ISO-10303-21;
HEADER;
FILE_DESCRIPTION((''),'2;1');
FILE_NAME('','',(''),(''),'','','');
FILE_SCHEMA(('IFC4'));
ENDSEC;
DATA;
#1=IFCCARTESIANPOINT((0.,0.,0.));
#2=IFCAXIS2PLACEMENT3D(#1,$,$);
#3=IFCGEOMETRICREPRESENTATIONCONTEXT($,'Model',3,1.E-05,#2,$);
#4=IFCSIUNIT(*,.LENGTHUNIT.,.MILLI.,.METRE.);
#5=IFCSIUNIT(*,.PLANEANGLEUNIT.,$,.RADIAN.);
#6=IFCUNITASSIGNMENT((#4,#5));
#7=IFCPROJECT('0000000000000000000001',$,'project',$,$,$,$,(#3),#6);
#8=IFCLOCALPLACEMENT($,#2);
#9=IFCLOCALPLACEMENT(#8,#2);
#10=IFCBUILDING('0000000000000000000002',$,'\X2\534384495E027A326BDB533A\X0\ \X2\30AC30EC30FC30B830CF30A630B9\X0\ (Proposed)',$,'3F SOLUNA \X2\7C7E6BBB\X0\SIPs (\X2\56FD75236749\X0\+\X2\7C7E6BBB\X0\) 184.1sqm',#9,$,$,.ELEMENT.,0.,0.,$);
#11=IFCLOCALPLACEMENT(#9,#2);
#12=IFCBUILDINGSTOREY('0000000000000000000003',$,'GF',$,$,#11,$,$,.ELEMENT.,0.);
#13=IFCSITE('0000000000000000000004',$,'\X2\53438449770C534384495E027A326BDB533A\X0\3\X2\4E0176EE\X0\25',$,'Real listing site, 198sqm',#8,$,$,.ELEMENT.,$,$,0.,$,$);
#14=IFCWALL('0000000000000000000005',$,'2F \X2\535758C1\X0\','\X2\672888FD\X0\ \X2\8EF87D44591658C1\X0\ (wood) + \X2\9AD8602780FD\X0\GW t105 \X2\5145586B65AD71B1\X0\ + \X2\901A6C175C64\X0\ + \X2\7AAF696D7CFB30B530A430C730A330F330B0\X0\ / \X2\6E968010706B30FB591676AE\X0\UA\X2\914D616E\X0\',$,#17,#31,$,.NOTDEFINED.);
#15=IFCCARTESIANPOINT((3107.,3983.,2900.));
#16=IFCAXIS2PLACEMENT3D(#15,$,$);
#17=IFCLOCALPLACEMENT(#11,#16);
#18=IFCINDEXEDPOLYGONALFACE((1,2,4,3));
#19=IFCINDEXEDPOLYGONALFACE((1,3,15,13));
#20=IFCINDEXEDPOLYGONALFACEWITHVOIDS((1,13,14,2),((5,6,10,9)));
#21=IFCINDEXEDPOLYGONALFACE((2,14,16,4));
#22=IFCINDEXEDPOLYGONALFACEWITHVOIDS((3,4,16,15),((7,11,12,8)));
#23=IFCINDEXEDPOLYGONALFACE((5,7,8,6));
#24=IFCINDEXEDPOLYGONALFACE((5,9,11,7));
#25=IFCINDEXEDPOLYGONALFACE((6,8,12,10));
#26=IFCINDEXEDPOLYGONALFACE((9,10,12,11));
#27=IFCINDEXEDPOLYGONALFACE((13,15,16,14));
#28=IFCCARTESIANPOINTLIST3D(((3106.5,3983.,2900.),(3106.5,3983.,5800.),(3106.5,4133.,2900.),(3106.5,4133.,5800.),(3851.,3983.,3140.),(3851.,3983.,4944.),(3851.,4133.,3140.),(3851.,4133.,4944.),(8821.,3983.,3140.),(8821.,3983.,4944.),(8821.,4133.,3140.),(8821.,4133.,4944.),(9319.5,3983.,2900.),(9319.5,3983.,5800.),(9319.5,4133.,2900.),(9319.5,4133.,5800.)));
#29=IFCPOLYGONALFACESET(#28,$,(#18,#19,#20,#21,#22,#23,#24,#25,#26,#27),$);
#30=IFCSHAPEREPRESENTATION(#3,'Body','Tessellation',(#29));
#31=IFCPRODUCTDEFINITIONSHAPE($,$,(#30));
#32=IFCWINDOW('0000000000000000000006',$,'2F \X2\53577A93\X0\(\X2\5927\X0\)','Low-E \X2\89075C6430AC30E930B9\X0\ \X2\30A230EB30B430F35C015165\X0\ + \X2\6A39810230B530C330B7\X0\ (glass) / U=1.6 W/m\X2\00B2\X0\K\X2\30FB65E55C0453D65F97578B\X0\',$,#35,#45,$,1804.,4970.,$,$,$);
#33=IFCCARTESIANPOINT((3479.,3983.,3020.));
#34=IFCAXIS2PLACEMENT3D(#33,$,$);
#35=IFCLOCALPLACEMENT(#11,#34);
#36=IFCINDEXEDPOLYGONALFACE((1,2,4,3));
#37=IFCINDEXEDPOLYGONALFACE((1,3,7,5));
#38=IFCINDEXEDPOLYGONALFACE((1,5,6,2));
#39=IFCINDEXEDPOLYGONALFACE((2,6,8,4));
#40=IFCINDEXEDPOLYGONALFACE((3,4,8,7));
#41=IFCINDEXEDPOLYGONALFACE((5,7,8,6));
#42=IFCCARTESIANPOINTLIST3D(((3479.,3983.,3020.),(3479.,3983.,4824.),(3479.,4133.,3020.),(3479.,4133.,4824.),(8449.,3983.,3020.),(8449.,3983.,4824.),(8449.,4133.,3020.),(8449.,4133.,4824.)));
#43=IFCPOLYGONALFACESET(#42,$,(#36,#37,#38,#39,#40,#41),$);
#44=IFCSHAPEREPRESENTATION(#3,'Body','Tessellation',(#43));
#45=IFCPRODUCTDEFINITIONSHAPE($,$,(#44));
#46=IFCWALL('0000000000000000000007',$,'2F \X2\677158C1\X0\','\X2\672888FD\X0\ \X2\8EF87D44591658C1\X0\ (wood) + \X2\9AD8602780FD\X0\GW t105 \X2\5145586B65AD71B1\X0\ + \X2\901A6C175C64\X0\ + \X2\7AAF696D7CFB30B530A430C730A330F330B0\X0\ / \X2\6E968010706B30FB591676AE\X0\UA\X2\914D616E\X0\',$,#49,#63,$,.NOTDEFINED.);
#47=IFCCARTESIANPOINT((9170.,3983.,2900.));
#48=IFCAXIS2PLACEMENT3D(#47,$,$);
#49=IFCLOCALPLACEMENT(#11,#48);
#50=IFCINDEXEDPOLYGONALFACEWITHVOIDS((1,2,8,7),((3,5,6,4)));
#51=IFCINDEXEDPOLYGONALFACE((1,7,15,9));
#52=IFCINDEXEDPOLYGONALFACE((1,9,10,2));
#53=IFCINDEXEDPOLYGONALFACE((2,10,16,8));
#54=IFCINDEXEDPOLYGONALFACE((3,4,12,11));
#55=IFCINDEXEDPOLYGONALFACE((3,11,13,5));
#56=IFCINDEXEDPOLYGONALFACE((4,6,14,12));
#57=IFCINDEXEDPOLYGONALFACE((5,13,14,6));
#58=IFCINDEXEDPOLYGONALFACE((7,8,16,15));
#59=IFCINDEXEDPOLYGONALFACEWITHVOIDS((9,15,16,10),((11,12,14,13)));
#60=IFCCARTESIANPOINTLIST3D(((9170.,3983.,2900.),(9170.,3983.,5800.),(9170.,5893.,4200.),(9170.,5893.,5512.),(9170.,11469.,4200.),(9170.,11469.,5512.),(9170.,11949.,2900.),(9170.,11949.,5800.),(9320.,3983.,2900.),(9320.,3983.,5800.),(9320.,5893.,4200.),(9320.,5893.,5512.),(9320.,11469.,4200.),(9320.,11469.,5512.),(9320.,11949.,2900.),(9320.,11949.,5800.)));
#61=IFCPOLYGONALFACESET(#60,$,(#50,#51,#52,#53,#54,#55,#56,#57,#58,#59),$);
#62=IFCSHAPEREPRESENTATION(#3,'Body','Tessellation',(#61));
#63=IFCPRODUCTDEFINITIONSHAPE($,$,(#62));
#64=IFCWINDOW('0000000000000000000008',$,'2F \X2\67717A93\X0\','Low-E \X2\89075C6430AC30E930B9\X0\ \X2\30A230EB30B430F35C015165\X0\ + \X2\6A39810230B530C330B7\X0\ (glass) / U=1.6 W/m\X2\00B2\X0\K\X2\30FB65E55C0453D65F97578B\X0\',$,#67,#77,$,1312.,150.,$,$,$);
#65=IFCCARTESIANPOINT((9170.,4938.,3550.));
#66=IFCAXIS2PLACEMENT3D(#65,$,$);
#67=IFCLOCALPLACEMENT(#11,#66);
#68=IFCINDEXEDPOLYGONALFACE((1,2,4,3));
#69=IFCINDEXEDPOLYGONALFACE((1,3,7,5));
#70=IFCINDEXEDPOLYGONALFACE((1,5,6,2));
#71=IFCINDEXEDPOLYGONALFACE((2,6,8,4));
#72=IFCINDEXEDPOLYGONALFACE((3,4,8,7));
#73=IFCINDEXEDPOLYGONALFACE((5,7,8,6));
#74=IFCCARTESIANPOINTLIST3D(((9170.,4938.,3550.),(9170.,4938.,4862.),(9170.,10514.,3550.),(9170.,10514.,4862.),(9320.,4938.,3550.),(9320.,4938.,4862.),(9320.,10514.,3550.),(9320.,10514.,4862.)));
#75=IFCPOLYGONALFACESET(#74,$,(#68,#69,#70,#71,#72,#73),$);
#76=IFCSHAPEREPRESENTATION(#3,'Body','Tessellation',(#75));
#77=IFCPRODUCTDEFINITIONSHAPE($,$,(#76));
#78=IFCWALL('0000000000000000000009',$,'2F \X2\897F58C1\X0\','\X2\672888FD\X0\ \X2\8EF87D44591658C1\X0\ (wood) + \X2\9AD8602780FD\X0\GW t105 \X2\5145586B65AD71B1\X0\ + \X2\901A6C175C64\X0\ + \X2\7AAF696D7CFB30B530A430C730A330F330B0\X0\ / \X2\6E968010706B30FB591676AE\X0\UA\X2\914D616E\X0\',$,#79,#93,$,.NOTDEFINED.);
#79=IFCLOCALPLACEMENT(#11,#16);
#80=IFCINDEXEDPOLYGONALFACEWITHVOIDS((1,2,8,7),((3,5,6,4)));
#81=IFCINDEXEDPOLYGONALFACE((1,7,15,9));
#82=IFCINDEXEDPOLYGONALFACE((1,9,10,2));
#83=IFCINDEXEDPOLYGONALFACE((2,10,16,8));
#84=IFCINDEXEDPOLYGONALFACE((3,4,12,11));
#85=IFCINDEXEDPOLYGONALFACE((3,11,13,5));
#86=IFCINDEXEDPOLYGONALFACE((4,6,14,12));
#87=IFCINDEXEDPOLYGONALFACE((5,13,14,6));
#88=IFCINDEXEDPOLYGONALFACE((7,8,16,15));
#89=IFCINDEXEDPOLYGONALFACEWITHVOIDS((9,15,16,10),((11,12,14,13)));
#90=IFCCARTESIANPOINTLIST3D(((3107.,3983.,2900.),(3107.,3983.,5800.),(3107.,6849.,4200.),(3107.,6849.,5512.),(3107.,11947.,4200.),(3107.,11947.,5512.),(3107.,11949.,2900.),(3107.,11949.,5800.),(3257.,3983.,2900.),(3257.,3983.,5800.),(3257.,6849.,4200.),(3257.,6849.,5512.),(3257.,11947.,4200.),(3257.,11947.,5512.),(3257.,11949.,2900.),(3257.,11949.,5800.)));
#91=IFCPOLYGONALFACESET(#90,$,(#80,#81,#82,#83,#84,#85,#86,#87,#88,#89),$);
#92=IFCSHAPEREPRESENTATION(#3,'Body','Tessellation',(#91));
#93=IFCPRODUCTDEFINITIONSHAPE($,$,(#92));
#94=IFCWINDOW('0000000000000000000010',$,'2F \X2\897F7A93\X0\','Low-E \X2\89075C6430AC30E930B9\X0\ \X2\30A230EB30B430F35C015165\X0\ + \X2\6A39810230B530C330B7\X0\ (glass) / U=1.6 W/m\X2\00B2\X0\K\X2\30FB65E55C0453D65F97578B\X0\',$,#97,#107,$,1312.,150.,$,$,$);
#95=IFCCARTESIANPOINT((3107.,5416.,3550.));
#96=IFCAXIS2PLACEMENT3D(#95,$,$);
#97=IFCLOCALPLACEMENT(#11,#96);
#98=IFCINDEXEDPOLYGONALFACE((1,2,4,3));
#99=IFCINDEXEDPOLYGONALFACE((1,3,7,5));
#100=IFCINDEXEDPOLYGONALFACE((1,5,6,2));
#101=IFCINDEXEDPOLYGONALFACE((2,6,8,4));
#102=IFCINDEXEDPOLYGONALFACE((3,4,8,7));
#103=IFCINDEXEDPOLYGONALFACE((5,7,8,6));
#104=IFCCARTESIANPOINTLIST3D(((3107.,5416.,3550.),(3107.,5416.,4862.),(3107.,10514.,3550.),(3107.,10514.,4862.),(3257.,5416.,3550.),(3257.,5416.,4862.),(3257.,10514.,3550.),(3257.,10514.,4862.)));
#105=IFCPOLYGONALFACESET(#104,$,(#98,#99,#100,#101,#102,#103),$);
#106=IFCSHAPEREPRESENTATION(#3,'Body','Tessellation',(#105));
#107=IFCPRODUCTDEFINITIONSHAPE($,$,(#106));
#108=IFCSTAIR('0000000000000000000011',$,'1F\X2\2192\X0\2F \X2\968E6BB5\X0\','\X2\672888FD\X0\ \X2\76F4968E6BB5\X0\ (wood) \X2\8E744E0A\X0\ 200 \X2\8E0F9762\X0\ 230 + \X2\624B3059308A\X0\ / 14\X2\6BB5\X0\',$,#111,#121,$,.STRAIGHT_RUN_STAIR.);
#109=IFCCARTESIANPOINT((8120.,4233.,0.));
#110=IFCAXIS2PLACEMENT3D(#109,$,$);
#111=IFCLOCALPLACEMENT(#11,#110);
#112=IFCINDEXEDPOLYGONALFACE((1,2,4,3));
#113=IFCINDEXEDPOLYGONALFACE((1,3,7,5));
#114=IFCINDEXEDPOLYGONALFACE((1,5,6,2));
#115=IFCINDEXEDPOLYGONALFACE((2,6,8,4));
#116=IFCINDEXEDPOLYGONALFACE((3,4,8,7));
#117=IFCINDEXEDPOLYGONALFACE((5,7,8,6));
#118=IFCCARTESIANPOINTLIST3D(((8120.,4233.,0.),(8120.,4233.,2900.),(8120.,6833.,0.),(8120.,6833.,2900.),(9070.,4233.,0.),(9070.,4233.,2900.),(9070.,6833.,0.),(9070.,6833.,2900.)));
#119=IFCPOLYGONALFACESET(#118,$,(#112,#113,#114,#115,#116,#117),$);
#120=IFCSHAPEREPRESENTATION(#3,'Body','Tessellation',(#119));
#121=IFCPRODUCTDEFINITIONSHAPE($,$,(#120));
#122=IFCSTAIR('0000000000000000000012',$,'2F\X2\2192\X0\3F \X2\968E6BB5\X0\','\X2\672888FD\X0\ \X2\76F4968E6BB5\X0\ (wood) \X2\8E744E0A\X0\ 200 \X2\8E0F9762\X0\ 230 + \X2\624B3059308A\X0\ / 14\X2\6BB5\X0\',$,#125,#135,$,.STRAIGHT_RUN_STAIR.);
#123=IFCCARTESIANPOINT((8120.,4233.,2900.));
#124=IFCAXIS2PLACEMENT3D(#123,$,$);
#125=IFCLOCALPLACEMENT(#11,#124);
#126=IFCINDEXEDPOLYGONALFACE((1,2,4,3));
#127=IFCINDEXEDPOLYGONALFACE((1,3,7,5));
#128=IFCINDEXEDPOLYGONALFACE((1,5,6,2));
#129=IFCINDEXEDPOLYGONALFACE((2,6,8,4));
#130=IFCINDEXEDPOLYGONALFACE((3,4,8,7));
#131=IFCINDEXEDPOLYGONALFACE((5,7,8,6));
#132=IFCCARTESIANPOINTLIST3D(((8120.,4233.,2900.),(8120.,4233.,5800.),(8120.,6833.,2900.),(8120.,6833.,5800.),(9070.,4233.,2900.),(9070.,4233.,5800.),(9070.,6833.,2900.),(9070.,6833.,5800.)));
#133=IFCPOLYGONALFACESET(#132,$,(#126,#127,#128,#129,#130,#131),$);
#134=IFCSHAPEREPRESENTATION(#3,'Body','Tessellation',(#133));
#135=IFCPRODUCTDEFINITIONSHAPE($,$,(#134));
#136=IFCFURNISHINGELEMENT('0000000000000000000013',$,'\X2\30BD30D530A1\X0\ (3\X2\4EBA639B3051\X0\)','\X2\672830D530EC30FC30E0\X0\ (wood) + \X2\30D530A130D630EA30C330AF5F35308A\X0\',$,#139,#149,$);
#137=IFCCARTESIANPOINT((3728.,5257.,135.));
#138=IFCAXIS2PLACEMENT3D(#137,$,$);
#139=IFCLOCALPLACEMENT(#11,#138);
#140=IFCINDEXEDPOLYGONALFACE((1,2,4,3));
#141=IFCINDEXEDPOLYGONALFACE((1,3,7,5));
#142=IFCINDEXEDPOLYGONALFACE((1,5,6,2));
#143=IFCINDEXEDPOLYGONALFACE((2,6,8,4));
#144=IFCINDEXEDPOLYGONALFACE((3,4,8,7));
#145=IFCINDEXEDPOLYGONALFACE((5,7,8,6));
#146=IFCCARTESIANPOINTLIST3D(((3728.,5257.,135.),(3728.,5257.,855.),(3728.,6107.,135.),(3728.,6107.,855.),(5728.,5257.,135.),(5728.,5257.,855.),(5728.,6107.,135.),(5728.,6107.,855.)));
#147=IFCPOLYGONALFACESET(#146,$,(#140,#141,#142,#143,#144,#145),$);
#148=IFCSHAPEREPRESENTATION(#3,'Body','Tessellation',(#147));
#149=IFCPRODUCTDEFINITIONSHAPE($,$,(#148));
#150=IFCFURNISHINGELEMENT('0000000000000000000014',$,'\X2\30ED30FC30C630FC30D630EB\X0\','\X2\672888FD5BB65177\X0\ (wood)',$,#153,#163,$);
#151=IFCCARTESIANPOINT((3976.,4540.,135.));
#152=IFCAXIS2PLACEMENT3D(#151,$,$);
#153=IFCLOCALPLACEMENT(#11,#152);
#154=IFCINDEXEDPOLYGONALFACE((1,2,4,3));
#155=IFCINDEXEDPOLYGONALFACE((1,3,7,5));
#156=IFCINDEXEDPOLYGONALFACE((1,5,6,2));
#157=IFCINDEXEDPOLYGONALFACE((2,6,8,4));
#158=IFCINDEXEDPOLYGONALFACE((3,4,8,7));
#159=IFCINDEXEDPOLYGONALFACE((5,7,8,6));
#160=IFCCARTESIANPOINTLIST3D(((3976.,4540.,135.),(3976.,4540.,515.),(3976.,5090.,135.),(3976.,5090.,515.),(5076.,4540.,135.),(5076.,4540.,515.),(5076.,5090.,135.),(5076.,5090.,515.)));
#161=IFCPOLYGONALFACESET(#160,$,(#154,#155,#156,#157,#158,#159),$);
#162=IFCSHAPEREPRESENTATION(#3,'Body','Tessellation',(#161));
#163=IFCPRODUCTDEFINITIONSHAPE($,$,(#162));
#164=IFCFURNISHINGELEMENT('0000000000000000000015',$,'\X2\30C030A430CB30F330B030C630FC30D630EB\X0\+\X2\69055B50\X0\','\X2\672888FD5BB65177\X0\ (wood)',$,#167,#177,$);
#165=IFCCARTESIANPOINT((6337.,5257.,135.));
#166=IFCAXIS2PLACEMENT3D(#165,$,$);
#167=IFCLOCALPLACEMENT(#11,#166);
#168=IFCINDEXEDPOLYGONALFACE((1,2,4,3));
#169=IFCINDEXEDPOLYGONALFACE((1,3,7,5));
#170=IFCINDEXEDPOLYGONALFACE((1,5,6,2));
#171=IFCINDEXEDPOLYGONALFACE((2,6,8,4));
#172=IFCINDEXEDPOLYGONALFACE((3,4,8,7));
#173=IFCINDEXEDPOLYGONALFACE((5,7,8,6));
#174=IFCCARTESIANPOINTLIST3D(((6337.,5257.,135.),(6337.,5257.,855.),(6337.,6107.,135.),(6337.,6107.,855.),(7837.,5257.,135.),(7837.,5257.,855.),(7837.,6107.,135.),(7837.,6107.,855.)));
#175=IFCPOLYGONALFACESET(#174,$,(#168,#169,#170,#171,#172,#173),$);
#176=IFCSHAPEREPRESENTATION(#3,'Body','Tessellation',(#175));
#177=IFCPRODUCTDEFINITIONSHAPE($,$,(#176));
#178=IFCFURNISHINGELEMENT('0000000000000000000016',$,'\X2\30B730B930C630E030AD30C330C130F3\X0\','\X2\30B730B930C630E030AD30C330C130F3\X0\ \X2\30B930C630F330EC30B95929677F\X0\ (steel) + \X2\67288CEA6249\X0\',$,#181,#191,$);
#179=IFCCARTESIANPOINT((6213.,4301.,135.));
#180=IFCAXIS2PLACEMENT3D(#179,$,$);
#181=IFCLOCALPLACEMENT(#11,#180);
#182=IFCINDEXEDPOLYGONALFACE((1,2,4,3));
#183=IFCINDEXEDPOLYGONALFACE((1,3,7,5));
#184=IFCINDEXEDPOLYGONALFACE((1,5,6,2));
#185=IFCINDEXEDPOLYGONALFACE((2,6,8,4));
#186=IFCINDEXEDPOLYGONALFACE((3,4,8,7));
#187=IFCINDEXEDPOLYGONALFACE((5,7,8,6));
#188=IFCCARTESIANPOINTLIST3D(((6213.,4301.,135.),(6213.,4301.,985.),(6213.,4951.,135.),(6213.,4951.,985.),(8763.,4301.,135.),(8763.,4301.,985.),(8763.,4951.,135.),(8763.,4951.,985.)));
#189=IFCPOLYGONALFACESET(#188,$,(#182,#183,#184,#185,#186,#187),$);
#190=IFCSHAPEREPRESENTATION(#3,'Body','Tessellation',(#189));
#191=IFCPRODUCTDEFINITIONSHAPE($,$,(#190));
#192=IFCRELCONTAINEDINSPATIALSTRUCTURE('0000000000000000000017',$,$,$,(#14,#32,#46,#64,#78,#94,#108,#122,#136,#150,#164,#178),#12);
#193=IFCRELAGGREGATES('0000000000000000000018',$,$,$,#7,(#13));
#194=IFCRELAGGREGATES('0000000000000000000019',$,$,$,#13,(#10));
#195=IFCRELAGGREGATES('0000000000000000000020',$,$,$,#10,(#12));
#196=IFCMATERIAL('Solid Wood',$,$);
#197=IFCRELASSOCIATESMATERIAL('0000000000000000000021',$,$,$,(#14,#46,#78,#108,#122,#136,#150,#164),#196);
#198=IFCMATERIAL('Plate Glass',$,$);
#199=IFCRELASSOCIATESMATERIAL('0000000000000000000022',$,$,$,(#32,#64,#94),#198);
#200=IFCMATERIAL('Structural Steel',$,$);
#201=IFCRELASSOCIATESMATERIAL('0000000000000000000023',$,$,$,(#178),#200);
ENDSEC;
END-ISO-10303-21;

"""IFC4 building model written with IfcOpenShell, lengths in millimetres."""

from ifc_helpers import new_model, si_unit, frame, frame_2d, origin, place, context, project, spatial, rectangle, extrude, material, element, fill, save


model = new_model("IFC4")

# Units and contexts
model_context = context("Model", 3, precision=1e-05, world=origin())
ifc_project = project(units=[si_unit("LENGTHUNIT", "METRE", prefix="MILLI"), si_unit("PLANEANGLEUNIT", "RADIAN")], contexts=[model_context])

# Site, building, storey
site_placement = place(None, origin())
site = spatial("IfcSite", under=ifc_project, at=site_placement, Name="千葉県千葉市稲毛区3丁目25", ObjectType="Real listing site, 198sqm", CompositionType="ELEMENT", RefElevation=0.0)
building_placement = place(site_placement, origin())
building = spatial("IfcBuilding", under=site, at=building_placement, Name="千葉市稲毛区 ガレージハウス (Proposed)", ObjectType="3F SOLUNA 籾殻SIPs (国産杉+籾殻) 184.1sqm", CompositionType="ELEMENT", ElevationOfRefHeight=0.0, ElevationOfTerrain=0.0)
storey_placement = place(building_placement, origin())
storey = spatial("IfcBuildingStorey", under=building, at=storey_placement, Name="GF", CompositionType="ELEMENT", Elevation=0.0)

# Shared definitions
ifc_material_1 = material(Name="Solid Wood")

# Shared definitions
ifc_material_2 = material(Name="Plate Glass")

# Walls, openings, windows
wall_1_placement = place(storey_placement, frame((3107.0, 3983.0, 2900.0)))
wall_1 = element("IfcWall", 1, at=wall_1_placement, inside=storey, material=ifc_material_1, Name="2F 南壁", Description="木製 軸組外壁 (wood) + 高性能GW t105 充填断熱 + 通気層 + 窯業系サイディング / 準耐火・外皮UA配慮", PredefinedType="NOTDEFINED", context=model_context, shape_type="SweptSolid", body=[
    extrude(rectangle(XDim=6213.0, YDim=150.0, at=frame_2d((3106.0, 75.0))), frame((3107.0, 3983.0, 2900.0)), (0.0, 0.0, 1.0), 2900.0),
])
opening_1_placement = place(storey_placement, frame((3479.0, 3983.0, 3020.0)))
opening_1 = element("IfcOpeningElement", 2, at=opening_1_placement, cuts=wall_1, PredefinedType="NOTDEFINED", context=model_context, shape_type="SweptSolid", body=[
    extrude(rectangle(XDim=4970.0, YDim=150.0, at=frame_2d((2485.0, 75.0))), frame((3479.0, 3983.0, 3020.0)), (0.0, 0.0, 1.0), 1804.0),
])
window_1_placement = place(storey_placement, frame((3479.0, 3983.0, 3020.0)))
window_1 = element("IfcWindow", 3, at=window_1_placement, inside=storey, material=ifc_material_2, Name="2F 南窓(大)", Description="Low-E 複層ガラス アルゴン封入 + 樹脂サッシ (glass) / U=1.6 W/m²K・日射取得型", OverallHeight=1804.0, OverallWidth=4970.0, context=model_context, shape_type="SweptSolid", body=[
    extrude(rectangle(XDim=4970.0, YDim=150.0, at=frame_2d((2485.0, 75.0))), frame((3479.0, 3983.0, 3020.0)), (0.0, 0.0, 1.0), 1804.0),
])
fill(opening_1, window_1)
wall_2_placement = place(storey_placement, frame((9170.0, 3983.0, 2900.0)))
wall_2 = element("IfcWall", 4, at=wall_2_placement, inside=storey, material=ifc_material_1, Name="2F 東壁", Description="木製 軸組外壁 (wood) + 高性能GW t105 充填断熱 + 通気層 + 窯業系サイディング / 準耐火・外皮UA配慮", PredefinedType="NOTDEFINED", context=model_context, shape_type="SweptSolid", body=[
    extrude(rectangle(XDim=150.0, YDim=7966.0, at=frame_2d((75.0, 3983.0))), frame((9170.0, 3983.0, 2900.0)), (0.0, 0.0, 1.0), 2900.0),
])
opening_2_placement = place(storey_placement, frame((9170.0, 4938.0, 3550.0)))
opening_2 = element("IfcOpeningElement", 5, at=opening_2_placement, cuts=wall_2, PredefinedType="NOTDEFINED", context=model_context, shape_type="SweptSolid", body=[
    extrude(rectangle(XDim=150.0, YDim=5576.0, at=frame_2d((75.0, 2788.0))), frame((9170.0, 4938.0, 3550.0)), (0.0, 0.0, 1.0), 1312.0),
])
window_2_placement = place(storey_placement, frame((9170.0, 4938.0, 3550.0)))
window_2 = element("IfcWindow", 6, at=window_2_placement, inside=storey, material=ifc_material_2, Name="2F 東窓", Description="Low-E 複層ガラス アルゴン封入 + 樹脂サッシ (glass) / U=1.6 W/m²K・日射取得型", OverallHeight=1312.0, OverallWidth=150.0, context=model_context, shape_type="SweptSolid", body=[
    extrude(rectangle(XDim=150.0, YDim=5576.0, at=frame_2d((75.0, 2788.0))), frame((9170.0, 4938.0, 3550.0)), (0.0, 0.0, 1.0), 1312.0),
])
fill(opening_2, window_2)
wall_3_placement = place(storey_placement, frame((3107.0, 3983.0, 2900.0)))
wall_3 = element("IfcWall", 7, at=wall_3_placement, inside=storey, material=ifc_material_1, Name="2F 西壁", Description="木製 軸組外壁 (wood) + 高性能GW t105 充填断熱 + 通気層 + 窯業系サイディング / 準耐火・外皮UA配慮", PredefinedType="NOTDEFINED", context=model_context, shape_type="SweptSolid", body=[
    extrude(rectangle(XDim=150.0, YDim=7966.0, at=frame_2d((75.0, 3983.0))), frame((3107.0, 3983.0, 2900.0)), (0.0, 0.0, 1.0), 2900.0),
])
opening_3_placement = place(storey_placement, frame((3107.0, 5416.0, 3550.0)))
opening_3 = element("IfcOpeningElement", 8, at=opening_3_placement, cuts=wall_3, PredefinedType="NOTDEFINED", context=model_context, shape_type="SweptSolid", body=[
    extrude(rectangle(XDim=150.0, YDim=5098.0, at=frame_2d((75.0, 2549.0))), frame((3107.0, 5416.0, 3550.0)), (0.0, 0.0, 1.0), 1312.0),
])
window_3_placement = place(storey_placement, frame((3107.0, 5416.0, 3550.0)))
window_3 = element("IfcWindow", 9, at=window_3_placement, inside=storey, material=ifc_material_2, Name="2F 西窓", Description="Low-E 複層ガラス アルゴン封入 + 樹脂サッシ (glass) / U=1.6 W/m²K・日射取得型", OverallHeight=1312.0, OverallWidth=150.0, context=model_context, shape_type="SweptSolid", body=[
    extrude(rectangle(XDim=150.0, YDim=5098.0, at=frame_2d((75.0, 2549.0))), frame((3107.0, 5416.0, 3550.0)), (0.0, 0.0, 1.0), 1312.0),
])
fill(opening_3, window_3)

# Stairs
stair_1_placement = place(storey_placement, frame((8120.0, 4233.0, 0.0)))
element("IfcStair", 10, at=stair_1_placement, inside=storey, material=ifc_material_1, Name="1F→2F 階段", Description="木製 直階段 (wood) 蹴上 200 踏面 230 + 手すり / 14段", PredefinedType="STRAIGHT_RUN_STAIR", context=model_context, shape_type="SweptSolid", body=[
    extrude(rectangle(XDim=950.0, YDim=2600.0, at=frame_2d((475.0, 1300.0))), frame((8120.0, 4233.0, 0.0)), (0.0, 0.0, 1.0), 2900.0),
])
stair_2_placement = place(storey_placement, frame((8120.0, 4233.0, 2900.0)))
element("IfcStair", 11, at=stair_2_placement, inside=storey, material=ifc_material_1, Name="2F→3F 階段", Description="木製 直階段 (wood) 蹴上 200 踏面 230 + 手すり / 14段", PredefinedType="STRAIGHT_RUN_STAIR", context=model_context, shape_type="SweptSolid", body=[
    extrude(rectangle(XDim=950.0, YDim=2600.0, at=frame_2d((475.0, 1300.0))), frame((8120.0, 4233.0, 2900.0)), (0.0, 0.0, 1.0), 2900.0),
])

# Furnishing elements
furnishing_1_placement = place(storey_placement, frame((3728.0, 5257.0, 135.0)))
element("IfcFurnishingElement", 12, at=furnishing_1_placement, inside=storey, material=ifc_material_1, Name="ソファ (3人掛け)", Description="木フレーム (wood) + ファブリック張り", context=model_context, shape_type="SweptSolid", body=[
    extrude(rectangle(XDim=2000.0, YDim=850.0, at=frame_2d((1000.0, 425.0))), frame((3728.0, 5257.0, 135.0)), (0.0, 0.0, 1.0), 720.0),
])
furnishing_2_placement = place(storey_placement, frame((3976.0, 4540.0, 135.0)))
element("IfcFurnishingElement", 13, at=furnishing_2_placement, inside=storey, material=ifc_material_1, Name="ローテーブル", Description="木製家具 (wood)", context=model_context, shape_type="SweptSolid", body=[
    extrude(rectangle(XDim=1100.0, YDim=550.0, at=frame_2d((550.0, 275.0))), frame((3976.0, 4540.0, 135.0)), (0.0, 0.0, 1.0), 380.0),
])
furnishing_3_placement = place(storey_placement, frame((6337.0, 5257.0, 135.0)))
element("IfcFurnishingElement", 14, at=furnishing_3_placement, inside=storey, material=ifc_material_1, Name="ダイニングテーブル+椅子", Description="木製家具 (wood)", context=model_context, shape_type="SweptSolid", body=[
    extrude(rectangle(XDim=1500.0, YDim=850.0, at=frame_2d((750.0, 425.0))), frame((6337.0, 5257.0, 135.0)), (0.0, 0.0, 1.0), 720.0),
])
ifc_material_3 = material(Name="Structural Steel")
furnishing_4_placement = place(storey_placement, frame((6213.0, 4301.0, 135.0)))
element("IfcFurnishingElement", 15, at=furnishing_4_placement, inside=storey, material=ifc_material_3, Name="システムキッチン", Description="システムキッチン ステンレス天板 (steel) + 木質扉", context=model_context, shape_type="SweptSolid", body=[
    extrude(rectangle(XDim=2550.0, YDim=650.0, at=frame_2d((1275.0, 325.0))), frame((6213.0, 4301.0, 135.0)), (0.0, 0.0, 1.0), 850.0),
])

save(model, "model.ifc")
